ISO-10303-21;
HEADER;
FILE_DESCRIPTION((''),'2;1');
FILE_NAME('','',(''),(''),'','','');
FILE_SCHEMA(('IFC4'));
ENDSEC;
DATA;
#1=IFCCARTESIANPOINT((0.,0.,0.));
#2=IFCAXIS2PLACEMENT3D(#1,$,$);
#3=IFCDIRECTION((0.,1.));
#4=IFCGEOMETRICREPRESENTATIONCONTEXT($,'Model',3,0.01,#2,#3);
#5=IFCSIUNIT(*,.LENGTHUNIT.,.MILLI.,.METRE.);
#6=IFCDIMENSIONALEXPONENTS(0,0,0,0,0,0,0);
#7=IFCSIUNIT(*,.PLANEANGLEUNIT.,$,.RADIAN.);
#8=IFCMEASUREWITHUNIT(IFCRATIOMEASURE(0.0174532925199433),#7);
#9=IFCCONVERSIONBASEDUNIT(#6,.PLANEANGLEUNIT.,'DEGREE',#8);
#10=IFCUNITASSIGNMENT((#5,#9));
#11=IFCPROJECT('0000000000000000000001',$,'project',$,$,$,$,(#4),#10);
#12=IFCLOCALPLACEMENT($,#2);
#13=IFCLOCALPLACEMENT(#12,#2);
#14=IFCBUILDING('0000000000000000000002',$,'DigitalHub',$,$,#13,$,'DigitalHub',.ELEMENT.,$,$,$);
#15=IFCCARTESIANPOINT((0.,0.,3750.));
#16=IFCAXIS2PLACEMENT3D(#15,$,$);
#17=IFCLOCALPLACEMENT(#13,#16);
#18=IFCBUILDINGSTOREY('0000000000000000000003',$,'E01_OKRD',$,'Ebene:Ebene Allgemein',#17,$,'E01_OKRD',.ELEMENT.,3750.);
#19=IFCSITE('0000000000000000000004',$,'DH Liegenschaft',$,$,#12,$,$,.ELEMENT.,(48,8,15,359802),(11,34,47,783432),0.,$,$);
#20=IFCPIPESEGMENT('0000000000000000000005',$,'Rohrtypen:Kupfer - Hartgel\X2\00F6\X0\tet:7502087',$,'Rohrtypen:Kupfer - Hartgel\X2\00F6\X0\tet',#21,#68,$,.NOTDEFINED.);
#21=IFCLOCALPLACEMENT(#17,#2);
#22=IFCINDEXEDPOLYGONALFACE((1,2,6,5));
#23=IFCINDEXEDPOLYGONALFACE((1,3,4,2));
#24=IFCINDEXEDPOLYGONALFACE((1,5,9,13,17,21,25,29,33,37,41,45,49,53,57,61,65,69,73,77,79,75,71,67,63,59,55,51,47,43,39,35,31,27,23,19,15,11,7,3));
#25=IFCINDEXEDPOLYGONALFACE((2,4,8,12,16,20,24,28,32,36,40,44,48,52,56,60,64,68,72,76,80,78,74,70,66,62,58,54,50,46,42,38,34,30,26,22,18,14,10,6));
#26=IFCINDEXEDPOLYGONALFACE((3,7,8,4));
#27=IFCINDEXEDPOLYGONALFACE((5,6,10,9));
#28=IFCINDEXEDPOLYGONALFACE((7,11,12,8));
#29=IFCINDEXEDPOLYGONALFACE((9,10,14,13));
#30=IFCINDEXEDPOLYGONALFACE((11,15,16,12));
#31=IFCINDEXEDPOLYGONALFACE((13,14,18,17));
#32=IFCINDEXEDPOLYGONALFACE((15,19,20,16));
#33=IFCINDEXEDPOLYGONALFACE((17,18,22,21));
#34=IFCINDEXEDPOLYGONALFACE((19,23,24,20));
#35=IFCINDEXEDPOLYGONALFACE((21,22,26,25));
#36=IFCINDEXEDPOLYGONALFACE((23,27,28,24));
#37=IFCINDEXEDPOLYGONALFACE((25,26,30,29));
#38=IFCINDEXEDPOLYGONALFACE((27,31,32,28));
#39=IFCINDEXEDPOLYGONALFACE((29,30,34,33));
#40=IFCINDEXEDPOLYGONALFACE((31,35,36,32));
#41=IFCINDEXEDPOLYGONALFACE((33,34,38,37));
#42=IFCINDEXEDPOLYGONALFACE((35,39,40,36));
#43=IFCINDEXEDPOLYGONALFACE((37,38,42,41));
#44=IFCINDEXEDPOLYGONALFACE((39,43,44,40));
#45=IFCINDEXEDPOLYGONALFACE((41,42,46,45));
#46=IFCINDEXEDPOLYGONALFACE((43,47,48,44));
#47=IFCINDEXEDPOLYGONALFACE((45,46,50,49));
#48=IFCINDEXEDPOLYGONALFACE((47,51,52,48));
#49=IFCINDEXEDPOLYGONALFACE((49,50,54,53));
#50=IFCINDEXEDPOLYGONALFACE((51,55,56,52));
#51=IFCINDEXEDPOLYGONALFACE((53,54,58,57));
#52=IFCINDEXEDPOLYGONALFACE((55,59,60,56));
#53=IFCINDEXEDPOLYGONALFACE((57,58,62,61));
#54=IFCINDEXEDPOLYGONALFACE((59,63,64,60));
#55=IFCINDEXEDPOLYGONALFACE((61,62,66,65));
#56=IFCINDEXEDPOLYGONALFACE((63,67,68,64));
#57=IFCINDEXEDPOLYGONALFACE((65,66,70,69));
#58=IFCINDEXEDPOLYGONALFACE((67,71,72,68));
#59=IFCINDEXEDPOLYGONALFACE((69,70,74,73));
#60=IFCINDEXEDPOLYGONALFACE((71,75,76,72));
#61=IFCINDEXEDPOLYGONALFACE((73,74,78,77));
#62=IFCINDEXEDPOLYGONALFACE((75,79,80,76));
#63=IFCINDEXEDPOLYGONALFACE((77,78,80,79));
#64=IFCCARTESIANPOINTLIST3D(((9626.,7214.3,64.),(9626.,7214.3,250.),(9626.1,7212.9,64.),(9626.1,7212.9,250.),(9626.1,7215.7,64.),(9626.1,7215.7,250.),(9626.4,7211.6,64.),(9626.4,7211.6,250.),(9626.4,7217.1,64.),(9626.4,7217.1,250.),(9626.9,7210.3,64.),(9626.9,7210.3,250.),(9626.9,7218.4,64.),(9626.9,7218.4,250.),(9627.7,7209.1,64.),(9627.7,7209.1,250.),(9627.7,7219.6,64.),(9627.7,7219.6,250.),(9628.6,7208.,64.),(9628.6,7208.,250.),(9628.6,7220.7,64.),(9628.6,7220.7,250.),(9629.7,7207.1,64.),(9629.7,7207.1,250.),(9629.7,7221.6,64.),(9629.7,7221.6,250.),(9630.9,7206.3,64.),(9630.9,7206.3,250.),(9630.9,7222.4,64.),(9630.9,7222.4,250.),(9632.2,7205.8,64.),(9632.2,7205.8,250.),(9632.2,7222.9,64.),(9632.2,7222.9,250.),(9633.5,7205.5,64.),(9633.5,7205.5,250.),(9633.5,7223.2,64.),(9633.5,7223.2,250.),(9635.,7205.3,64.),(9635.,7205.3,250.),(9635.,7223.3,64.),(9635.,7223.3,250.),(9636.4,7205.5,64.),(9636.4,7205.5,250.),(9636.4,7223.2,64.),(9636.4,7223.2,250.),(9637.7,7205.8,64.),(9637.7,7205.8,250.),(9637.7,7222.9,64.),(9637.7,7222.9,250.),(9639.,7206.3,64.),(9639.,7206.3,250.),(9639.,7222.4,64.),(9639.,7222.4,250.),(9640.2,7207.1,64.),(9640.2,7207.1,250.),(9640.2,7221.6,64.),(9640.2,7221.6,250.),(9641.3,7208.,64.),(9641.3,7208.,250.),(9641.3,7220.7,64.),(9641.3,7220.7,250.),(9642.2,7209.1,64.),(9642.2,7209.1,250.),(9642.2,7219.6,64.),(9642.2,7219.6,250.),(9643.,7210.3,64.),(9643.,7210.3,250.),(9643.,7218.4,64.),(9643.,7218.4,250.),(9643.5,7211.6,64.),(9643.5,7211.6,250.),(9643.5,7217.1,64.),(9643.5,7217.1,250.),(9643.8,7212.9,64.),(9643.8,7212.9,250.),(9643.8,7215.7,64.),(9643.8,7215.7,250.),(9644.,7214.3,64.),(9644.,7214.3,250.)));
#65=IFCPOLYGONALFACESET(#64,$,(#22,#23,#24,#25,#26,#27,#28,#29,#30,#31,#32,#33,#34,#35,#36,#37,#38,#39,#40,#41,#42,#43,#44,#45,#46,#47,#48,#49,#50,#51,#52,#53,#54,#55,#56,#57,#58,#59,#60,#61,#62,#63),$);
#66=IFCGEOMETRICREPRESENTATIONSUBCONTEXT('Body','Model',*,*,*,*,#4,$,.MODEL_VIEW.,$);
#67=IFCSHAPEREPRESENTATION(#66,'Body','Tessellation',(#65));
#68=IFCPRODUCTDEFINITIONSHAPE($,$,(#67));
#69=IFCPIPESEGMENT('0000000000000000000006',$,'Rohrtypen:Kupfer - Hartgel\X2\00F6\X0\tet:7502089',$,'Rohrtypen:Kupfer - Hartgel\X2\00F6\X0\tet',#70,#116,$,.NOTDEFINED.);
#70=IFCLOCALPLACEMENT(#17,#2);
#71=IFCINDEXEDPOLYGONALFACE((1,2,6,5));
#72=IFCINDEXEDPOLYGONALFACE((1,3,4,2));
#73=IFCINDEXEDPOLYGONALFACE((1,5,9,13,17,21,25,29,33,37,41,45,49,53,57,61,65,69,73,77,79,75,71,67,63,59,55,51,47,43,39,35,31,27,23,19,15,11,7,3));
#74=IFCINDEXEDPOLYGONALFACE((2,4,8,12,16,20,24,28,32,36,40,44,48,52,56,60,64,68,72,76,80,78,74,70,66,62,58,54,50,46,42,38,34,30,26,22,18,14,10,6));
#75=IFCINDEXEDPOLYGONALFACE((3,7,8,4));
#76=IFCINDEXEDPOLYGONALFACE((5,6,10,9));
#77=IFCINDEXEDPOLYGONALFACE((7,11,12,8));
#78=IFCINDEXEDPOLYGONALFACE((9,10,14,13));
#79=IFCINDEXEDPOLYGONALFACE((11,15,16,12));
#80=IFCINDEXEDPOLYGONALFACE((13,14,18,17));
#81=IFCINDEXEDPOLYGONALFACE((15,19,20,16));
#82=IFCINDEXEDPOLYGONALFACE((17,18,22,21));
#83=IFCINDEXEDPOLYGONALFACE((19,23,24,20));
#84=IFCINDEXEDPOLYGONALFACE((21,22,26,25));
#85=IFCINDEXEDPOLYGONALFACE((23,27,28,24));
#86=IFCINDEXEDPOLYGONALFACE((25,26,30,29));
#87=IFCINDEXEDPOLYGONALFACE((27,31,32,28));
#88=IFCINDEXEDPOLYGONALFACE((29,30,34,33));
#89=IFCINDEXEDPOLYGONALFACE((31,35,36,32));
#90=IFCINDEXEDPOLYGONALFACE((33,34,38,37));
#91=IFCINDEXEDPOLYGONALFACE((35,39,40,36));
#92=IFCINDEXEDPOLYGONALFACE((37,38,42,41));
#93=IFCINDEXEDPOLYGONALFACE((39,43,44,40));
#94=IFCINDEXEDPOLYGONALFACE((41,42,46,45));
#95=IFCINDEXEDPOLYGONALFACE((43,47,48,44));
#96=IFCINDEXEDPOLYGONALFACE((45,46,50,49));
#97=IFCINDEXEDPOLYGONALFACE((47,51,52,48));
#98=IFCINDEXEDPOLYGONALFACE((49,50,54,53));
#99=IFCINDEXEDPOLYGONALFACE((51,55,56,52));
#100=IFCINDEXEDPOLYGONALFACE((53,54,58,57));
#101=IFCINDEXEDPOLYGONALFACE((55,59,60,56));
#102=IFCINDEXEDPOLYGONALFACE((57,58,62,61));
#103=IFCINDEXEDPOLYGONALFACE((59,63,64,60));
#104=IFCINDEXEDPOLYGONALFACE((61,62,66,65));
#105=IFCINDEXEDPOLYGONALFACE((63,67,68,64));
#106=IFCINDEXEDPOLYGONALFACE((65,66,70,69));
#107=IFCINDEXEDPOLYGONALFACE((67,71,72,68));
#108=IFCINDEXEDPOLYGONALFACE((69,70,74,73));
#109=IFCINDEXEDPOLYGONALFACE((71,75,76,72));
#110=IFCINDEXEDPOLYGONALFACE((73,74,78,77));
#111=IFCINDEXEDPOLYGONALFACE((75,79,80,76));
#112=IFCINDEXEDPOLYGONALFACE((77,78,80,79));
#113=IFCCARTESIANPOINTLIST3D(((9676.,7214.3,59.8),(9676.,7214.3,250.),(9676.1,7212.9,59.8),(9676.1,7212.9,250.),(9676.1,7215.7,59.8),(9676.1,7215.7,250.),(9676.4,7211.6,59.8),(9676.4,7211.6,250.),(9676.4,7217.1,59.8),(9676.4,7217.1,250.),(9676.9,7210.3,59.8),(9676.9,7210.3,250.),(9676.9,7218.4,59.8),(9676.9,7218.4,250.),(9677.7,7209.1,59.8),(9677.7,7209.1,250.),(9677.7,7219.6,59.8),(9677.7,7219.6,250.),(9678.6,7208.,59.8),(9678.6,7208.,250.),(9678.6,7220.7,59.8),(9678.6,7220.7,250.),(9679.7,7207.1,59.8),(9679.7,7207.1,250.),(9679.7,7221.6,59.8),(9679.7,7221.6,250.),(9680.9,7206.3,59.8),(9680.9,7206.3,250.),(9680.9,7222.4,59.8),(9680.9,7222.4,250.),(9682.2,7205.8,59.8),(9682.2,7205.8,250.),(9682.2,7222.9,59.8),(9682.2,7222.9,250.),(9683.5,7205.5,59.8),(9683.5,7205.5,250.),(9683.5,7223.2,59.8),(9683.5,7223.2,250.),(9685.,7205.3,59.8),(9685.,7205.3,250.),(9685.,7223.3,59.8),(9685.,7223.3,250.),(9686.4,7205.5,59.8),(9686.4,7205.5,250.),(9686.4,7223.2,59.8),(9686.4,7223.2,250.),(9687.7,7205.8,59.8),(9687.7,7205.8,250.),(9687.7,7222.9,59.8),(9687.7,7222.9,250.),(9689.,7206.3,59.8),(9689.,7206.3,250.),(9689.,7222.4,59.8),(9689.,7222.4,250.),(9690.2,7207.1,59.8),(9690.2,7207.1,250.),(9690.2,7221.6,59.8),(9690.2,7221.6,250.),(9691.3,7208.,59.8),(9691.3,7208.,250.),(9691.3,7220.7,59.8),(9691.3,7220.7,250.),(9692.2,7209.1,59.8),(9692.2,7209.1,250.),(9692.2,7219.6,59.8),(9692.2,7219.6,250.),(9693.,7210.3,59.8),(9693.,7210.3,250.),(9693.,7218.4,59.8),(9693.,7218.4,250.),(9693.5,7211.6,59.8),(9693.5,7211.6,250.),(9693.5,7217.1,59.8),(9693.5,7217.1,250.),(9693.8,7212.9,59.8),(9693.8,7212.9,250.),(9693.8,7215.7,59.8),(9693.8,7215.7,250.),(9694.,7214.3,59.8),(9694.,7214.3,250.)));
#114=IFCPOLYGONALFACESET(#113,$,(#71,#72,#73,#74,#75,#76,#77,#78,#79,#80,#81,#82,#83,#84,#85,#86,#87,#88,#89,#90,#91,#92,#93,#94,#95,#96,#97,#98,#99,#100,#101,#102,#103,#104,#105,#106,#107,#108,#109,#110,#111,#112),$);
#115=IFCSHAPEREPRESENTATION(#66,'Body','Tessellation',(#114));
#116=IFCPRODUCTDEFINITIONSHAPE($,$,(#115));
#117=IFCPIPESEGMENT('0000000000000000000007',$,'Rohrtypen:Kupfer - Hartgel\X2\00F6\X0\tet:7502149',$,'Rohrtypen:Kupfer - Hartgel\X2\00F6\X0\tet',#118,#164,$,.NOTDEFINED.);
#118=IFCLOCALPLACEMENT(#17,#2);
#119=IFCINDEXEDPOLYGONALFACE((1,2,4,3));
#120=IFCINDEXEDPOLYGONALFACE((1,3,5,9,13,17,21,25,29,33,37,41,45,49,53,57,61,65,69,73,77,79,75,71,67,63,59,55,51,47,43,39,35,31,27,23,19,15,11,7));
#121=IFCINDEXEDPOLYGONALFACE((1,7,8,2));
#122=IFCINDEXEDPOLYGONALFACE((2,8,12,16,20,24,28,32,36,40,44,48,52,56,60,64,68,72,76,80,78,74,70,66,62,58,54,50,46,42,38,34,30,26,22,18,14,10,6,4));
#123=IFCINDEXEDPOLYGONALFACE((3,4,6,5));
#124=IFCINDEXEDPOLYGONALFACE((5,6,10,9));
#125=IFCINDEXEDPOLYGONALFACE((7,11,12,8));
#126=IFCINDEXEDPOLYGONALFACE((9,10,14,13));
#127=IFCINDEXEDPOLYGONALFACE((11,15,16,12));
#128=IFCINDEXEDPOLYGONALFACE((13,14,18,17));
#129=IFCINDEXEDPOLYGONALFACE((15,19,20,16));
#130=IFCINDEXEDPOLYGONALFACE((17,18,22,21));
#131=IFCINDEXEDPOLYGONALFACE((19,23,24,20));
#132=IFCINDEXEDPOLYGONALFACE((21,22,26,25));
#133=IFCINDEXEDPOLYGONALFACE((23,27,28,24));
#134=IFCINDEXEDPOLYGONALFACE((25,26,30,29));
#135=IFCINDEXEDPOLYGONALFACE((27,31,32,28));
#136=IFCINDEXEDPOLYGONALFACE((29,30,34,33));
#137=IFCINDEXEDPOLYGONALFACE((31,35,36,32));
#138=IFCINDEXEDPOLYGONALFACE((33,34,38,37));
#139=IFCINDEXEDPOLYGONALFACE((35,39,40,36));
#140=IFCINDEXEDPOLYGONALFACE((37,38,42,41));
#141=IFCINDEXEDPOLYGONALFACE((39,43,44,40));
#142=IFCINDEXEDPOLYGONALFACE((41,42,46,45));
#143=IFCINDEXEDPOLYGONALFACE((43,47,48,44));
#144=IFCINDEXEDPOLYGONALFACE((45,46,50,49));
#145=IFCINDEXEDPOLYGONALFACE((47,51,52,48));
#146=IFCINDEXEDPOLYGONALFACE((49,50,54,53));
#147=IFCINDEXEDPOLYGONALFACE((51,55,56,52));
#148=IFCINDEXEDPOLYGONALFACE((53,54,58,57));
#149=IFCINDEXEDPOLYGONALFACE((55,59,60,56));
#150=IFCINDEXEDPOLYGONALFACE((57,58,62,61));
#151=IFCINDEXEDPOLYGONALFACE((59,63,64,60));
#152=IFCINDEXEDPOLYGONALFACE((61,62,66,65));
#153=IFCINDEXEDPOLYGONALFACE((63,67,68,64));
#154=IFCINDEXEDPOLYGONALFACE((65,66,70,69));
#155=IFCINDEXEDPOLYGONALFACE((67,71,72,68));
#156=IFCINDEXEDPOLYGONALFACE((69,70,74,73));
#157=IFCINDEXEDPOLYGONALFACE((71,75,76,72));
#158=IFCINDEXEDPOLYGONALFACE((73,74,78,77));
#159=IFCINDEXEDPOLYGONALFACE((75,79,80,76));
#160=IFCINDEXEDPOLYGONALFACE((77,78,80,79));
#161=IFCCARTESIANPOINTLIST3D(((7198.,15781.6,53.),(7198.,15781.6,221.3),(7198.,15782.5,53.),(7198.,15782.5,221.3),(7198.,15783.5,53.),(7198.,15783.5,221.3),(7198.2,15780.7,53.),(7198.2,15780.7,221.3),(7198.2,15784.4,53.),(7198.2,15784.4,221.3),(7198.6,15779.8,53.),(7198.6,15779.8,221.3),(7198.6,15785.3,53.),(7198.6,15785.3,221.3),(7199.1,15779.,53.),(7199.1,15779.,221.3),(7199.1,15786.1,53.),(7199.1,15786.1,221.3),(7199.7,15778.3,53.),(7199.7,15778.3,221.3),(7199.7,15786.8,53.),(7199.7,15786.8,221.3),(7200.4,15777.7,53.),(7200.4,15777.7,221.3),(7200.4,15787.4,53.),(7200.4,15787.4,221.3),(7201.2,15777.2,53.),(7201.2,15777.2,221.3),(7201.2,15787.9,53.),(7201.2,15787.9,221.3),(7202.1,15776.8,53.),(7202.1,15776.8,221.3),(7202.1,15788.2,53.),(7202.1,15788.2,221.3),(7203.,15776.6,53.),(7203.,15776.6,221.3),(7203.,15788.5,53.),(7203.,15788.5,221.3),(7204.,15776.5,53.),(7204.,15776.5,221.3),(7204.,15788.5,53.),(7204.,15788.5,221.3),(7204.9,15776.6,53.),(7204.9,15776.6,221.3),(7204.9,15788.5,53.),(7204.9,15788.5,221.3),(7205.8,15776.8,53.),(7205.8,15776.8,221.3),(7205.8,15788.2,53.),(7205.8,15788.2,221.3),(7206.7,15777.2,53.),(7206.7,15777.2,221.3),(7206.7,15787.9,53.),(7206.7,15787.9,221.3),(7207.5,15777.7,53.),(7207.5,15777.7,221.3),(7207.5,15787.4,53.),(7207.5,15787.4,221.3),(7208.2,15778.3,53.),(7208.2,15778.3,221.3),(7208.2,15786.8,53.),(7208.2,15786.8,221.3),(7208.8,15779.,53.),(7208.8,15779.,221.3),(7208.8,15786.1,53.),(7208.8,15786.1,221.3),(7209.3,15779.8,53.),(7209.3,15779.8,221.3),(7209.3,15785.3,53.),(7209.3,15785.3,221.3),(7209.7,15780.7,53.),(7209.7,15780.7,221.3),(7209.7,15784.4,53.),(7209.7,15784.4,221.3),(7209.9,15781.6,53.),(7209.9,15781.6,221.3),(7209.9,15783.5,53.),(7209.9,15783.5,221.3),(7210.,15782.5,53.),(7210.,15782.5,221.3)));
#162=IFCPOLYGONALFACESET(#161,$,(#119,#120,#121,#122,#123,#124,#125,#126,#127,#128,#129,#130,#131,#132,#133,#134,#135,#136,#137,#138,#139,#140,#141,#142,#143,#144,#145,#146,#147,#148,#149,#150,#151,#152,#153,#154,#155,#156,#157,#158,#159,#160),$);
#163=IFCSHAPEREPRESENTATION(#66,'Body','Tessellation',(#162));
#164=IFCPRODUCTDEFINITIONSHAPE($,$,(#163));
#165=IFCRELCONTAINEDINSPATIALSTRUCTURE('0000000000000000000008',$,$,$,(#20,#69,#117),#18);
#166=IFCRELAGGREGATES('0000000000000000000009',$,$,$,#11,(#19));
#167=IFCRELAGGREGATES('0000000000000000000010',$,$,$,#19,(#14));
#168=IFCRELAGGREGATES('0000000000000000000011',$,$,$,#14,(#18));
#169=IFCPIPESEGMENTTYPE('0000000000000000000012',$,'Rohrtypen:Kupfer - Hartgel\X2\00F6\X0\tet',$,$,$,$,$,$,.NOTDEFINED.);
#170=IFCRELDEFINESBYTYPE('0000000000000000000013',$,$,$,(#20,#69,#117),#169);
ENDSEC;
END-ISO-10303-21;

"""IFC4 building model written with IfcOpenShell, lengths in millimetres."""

from ifc_helpers import new_model, entity, si_unit, converted_unit, direction, frame, origin, place, context, subcontext, project, spatial, indexed_curve, outline, extrude, type_object, element, save


model = new_model("IFC4")

# Units and contexts
model_context = context("Model", 3, precision=0.01, world=origin(), true_north=direction((0.0, 1.0)))
body_context = subcontext(model_context, "Body", "Model", "MODEL_VIEW")
ifc_project = project(units=[si_unit("LENGTHUNIT", "METRE", prefix="MILLI"), converted_unit("PLANEANGLEUNIT", "DEGREE", entity("IfcRatioMeasure", 0.0174532925199433), si_unit("PLANEANGLEUNIT", "RADIAN"), dimensions=[0, 0, 0, 0, 0, 0, 0])], contexts=[model_context])

# Site, building, storey
site_placement = place(None, origin())
site = spatial("IfcSite", under=ifc_project, at=site_placement, Name="DH Liegenschaft", CompositionType="ELEMENT", RefLatitude=(48, 8, 15, 359802), RefLongitude=(11, 34, 47, 783432), RefElevation=0.0)
building_placement = place(site_placement, origin())
building = spatial("IfcBuilding", under=site, at=building_placement, Name="DigitalHub", LongName="DigitalHub", CompositionType="ELEMENT")
storey_placement = place(building_placement, frame((0.0, 0.0, 3750.0)))
storey = spatial("IfcBuildingStorey", under=building, at=storey_placement, Name="E01_OKRD", ObjectType="Ebene:Ebene Allgemein", LongName="E01_OKRD", CompositionType="ELEMENT", Elevation=3750.0)

# Pipe segments
pipe_segment_type = type_object("IfcPipeSegmentType", Name="Rohrtypen:Kupfer - Hartgelötet", PredefinedType="NOTDEFINED")
pipe_segment_1_placement = place(storey_placement, frame((9624.4, 7203.7, 64.0)))
element("IfcPipeSegment", 1, at=pipe_segment_1_placement, inside=storey, type_object=pipe_segment_type, Name="Rohrtypen:Kupfer - Hartgelötet:7502087", ObjectType="Rohrtypen:Kupfer - Hartgelötet", PredefinedType="NOTDEFINED", context=body_context, shape_type="SweptSolid", body=[
    extrude(outline(indexed_curve([(9.0, 0.0), (8.9, 1.4), (8.6, 2.8), (8.0, 4.1), (7.3, 5.3), (6.4, 6.4), (5.3, 7.3), (4.1, 8.0), (2.8, 8.6), (1.4, 8.9), (0.0, 9.0), (-1.4, 8.9), (-2.8, 8.6), (-4.1, 8.0), (-5.3, 7.3), (-6.4, 6.4), (-7.3, 5.3), (-8.0, 4.1), (-8.6, 2.8), (-8.9, 1.4), (-9.0, 0.0), (-8.9, -1.4), (-8.6, -2.8), (-8.0, -4.1), (-7.3, -5.3), (-6.4, -6.4), (-5.3, -7.3), (-4.1, -8.0), (-2.8, -8.6), (-1.4, -8.9), (0.0, -9.0), (1.4, -8.9), (2.8, -8.6), (4.1, -8.0), (5.3, -7.3), (6.4, -6.4), (7.3, -5.3), (8.0, -4.1), (8.6, -2.8), (8.9, -1.4), (9.0, 0.0)], self_intersect=False)), frame((10.6, 10.6, 0.0)), (0.0, 0.0, 1.0), 186.0),
])
pipe_segment_2_placement = place(storey_placement, frame((9674.4, 7203.7, 59.8)))
element("IfcPipeSegment", 2, at=pipe_segment_2_placement, inside=storey, type_object=pipe_segment_type, Name="Rohrtypen:Kupfer - Hartgelötet:7502089", ObjectType="Rohrtypen:Kupfer - Hartgelötet", PredefinedType="NOTDEFINED", context=body_context, shape_type="SweptSolid", body=[
    extrude(outline(indexed_curve([(9.0, 0.0), (8.9, 1.4), (8.6, 2.8), (8.0, 4.1), (7.3, 5.3), (6.4, 6.4), (5.3, 7.3), (4.1, 8.0), (2.8, 8.6), (1.4, 8.9), (0.0, 9.0), (-1.4, 8.9), (-2.8, 8.6), (-4.1, 8.0), (-5.3, 7.3), (-6.4, 6.4), (-7.3, 5.3), (-8.0, 4.1), (-8.6, 2.8), (-8.9, 1.4), (-9.0, 0.0), (-8.9, -1.4), (-8.6, -2.8), (-8.0, -4.1), (-7.3, -5.3), (-6.4, -6.4), (-5.3, -7.3), (-4.1, -8.0), (-2.8, -8.6), (-1.4, -8.9), (0.0, -9.0), (1.4, -8.9), (2.8, -8.6), (4.1, -8.0), (5.3, -7.3), (6.4, -6.4), (7.3, -5.3), (8.0, -4.1), (8.6, -2.8), (8.9, -1.4), (9.0, 0.0)], self_intersect=False)), frame((10.6, 10.6, 0.0)), (0.0, 0.0, 1.0), 190.2),
])
pipe_segment_3_placement = place(storey_placement, frame((7196.4, 15774.9, 53.0)))
element("IfcPipeSegment", 3, at=pipe_segment_3_placement, inside=storey, type_object=pipe_segment_type, Name="Rohrtypen:Kupfer - Hartgelötet:7502149", ObjectType="Rohrtypen:Kupfer - Hartgelötet", PredefinedType="NOTDEFINED", context=body_context, shape_type="SweptSolid", body=[
    extrude(outline(indexed_curve([(6.0, 0.0), (5.9, 0.9), (5.7, 1.9), (5.3, 2.7), (4.9, 3.5), (4.2, 4.2), (3.5, 4.9), (2.7, 5.3), (1.9, 5.7), (0.9, 5.9), (0.0, 6.0), (-0.9, 5.9), (-1.9, 5.7), (-2.7, 5.3), (-3.5, 4.9), (-4.2, 4.2), (-4.9, 3.5), (-5.3, 2.7), (-5.7, 1.9), (-5.9, 0.9), (-6.0, 0.0), (-5.9, -0.9), (-5.7, -1.9), (-5.3, -2.7), (-4.9, -3.5), (-4.2, -4.2), (-3.5, -4.9), (-2.7, -5.3), (-1.9, -5.7), (-0.9, -5.9), (0.0, -6.0), (0.9, -5.9), (1.9, -5.7), (2.7, -5.3), (3.5, -4.9), (4.2, -4.2), (4.9, -3.5), (5.3, -2.7), (5.7, -1.9), (5.9, -0.9), (6.0, 0.0)], self_intersect=False)), frame((7.6, 7.6, 0.0)), (0.0, 0.0, 1.0), 168.3),
])

save(model, "model.ifc")
